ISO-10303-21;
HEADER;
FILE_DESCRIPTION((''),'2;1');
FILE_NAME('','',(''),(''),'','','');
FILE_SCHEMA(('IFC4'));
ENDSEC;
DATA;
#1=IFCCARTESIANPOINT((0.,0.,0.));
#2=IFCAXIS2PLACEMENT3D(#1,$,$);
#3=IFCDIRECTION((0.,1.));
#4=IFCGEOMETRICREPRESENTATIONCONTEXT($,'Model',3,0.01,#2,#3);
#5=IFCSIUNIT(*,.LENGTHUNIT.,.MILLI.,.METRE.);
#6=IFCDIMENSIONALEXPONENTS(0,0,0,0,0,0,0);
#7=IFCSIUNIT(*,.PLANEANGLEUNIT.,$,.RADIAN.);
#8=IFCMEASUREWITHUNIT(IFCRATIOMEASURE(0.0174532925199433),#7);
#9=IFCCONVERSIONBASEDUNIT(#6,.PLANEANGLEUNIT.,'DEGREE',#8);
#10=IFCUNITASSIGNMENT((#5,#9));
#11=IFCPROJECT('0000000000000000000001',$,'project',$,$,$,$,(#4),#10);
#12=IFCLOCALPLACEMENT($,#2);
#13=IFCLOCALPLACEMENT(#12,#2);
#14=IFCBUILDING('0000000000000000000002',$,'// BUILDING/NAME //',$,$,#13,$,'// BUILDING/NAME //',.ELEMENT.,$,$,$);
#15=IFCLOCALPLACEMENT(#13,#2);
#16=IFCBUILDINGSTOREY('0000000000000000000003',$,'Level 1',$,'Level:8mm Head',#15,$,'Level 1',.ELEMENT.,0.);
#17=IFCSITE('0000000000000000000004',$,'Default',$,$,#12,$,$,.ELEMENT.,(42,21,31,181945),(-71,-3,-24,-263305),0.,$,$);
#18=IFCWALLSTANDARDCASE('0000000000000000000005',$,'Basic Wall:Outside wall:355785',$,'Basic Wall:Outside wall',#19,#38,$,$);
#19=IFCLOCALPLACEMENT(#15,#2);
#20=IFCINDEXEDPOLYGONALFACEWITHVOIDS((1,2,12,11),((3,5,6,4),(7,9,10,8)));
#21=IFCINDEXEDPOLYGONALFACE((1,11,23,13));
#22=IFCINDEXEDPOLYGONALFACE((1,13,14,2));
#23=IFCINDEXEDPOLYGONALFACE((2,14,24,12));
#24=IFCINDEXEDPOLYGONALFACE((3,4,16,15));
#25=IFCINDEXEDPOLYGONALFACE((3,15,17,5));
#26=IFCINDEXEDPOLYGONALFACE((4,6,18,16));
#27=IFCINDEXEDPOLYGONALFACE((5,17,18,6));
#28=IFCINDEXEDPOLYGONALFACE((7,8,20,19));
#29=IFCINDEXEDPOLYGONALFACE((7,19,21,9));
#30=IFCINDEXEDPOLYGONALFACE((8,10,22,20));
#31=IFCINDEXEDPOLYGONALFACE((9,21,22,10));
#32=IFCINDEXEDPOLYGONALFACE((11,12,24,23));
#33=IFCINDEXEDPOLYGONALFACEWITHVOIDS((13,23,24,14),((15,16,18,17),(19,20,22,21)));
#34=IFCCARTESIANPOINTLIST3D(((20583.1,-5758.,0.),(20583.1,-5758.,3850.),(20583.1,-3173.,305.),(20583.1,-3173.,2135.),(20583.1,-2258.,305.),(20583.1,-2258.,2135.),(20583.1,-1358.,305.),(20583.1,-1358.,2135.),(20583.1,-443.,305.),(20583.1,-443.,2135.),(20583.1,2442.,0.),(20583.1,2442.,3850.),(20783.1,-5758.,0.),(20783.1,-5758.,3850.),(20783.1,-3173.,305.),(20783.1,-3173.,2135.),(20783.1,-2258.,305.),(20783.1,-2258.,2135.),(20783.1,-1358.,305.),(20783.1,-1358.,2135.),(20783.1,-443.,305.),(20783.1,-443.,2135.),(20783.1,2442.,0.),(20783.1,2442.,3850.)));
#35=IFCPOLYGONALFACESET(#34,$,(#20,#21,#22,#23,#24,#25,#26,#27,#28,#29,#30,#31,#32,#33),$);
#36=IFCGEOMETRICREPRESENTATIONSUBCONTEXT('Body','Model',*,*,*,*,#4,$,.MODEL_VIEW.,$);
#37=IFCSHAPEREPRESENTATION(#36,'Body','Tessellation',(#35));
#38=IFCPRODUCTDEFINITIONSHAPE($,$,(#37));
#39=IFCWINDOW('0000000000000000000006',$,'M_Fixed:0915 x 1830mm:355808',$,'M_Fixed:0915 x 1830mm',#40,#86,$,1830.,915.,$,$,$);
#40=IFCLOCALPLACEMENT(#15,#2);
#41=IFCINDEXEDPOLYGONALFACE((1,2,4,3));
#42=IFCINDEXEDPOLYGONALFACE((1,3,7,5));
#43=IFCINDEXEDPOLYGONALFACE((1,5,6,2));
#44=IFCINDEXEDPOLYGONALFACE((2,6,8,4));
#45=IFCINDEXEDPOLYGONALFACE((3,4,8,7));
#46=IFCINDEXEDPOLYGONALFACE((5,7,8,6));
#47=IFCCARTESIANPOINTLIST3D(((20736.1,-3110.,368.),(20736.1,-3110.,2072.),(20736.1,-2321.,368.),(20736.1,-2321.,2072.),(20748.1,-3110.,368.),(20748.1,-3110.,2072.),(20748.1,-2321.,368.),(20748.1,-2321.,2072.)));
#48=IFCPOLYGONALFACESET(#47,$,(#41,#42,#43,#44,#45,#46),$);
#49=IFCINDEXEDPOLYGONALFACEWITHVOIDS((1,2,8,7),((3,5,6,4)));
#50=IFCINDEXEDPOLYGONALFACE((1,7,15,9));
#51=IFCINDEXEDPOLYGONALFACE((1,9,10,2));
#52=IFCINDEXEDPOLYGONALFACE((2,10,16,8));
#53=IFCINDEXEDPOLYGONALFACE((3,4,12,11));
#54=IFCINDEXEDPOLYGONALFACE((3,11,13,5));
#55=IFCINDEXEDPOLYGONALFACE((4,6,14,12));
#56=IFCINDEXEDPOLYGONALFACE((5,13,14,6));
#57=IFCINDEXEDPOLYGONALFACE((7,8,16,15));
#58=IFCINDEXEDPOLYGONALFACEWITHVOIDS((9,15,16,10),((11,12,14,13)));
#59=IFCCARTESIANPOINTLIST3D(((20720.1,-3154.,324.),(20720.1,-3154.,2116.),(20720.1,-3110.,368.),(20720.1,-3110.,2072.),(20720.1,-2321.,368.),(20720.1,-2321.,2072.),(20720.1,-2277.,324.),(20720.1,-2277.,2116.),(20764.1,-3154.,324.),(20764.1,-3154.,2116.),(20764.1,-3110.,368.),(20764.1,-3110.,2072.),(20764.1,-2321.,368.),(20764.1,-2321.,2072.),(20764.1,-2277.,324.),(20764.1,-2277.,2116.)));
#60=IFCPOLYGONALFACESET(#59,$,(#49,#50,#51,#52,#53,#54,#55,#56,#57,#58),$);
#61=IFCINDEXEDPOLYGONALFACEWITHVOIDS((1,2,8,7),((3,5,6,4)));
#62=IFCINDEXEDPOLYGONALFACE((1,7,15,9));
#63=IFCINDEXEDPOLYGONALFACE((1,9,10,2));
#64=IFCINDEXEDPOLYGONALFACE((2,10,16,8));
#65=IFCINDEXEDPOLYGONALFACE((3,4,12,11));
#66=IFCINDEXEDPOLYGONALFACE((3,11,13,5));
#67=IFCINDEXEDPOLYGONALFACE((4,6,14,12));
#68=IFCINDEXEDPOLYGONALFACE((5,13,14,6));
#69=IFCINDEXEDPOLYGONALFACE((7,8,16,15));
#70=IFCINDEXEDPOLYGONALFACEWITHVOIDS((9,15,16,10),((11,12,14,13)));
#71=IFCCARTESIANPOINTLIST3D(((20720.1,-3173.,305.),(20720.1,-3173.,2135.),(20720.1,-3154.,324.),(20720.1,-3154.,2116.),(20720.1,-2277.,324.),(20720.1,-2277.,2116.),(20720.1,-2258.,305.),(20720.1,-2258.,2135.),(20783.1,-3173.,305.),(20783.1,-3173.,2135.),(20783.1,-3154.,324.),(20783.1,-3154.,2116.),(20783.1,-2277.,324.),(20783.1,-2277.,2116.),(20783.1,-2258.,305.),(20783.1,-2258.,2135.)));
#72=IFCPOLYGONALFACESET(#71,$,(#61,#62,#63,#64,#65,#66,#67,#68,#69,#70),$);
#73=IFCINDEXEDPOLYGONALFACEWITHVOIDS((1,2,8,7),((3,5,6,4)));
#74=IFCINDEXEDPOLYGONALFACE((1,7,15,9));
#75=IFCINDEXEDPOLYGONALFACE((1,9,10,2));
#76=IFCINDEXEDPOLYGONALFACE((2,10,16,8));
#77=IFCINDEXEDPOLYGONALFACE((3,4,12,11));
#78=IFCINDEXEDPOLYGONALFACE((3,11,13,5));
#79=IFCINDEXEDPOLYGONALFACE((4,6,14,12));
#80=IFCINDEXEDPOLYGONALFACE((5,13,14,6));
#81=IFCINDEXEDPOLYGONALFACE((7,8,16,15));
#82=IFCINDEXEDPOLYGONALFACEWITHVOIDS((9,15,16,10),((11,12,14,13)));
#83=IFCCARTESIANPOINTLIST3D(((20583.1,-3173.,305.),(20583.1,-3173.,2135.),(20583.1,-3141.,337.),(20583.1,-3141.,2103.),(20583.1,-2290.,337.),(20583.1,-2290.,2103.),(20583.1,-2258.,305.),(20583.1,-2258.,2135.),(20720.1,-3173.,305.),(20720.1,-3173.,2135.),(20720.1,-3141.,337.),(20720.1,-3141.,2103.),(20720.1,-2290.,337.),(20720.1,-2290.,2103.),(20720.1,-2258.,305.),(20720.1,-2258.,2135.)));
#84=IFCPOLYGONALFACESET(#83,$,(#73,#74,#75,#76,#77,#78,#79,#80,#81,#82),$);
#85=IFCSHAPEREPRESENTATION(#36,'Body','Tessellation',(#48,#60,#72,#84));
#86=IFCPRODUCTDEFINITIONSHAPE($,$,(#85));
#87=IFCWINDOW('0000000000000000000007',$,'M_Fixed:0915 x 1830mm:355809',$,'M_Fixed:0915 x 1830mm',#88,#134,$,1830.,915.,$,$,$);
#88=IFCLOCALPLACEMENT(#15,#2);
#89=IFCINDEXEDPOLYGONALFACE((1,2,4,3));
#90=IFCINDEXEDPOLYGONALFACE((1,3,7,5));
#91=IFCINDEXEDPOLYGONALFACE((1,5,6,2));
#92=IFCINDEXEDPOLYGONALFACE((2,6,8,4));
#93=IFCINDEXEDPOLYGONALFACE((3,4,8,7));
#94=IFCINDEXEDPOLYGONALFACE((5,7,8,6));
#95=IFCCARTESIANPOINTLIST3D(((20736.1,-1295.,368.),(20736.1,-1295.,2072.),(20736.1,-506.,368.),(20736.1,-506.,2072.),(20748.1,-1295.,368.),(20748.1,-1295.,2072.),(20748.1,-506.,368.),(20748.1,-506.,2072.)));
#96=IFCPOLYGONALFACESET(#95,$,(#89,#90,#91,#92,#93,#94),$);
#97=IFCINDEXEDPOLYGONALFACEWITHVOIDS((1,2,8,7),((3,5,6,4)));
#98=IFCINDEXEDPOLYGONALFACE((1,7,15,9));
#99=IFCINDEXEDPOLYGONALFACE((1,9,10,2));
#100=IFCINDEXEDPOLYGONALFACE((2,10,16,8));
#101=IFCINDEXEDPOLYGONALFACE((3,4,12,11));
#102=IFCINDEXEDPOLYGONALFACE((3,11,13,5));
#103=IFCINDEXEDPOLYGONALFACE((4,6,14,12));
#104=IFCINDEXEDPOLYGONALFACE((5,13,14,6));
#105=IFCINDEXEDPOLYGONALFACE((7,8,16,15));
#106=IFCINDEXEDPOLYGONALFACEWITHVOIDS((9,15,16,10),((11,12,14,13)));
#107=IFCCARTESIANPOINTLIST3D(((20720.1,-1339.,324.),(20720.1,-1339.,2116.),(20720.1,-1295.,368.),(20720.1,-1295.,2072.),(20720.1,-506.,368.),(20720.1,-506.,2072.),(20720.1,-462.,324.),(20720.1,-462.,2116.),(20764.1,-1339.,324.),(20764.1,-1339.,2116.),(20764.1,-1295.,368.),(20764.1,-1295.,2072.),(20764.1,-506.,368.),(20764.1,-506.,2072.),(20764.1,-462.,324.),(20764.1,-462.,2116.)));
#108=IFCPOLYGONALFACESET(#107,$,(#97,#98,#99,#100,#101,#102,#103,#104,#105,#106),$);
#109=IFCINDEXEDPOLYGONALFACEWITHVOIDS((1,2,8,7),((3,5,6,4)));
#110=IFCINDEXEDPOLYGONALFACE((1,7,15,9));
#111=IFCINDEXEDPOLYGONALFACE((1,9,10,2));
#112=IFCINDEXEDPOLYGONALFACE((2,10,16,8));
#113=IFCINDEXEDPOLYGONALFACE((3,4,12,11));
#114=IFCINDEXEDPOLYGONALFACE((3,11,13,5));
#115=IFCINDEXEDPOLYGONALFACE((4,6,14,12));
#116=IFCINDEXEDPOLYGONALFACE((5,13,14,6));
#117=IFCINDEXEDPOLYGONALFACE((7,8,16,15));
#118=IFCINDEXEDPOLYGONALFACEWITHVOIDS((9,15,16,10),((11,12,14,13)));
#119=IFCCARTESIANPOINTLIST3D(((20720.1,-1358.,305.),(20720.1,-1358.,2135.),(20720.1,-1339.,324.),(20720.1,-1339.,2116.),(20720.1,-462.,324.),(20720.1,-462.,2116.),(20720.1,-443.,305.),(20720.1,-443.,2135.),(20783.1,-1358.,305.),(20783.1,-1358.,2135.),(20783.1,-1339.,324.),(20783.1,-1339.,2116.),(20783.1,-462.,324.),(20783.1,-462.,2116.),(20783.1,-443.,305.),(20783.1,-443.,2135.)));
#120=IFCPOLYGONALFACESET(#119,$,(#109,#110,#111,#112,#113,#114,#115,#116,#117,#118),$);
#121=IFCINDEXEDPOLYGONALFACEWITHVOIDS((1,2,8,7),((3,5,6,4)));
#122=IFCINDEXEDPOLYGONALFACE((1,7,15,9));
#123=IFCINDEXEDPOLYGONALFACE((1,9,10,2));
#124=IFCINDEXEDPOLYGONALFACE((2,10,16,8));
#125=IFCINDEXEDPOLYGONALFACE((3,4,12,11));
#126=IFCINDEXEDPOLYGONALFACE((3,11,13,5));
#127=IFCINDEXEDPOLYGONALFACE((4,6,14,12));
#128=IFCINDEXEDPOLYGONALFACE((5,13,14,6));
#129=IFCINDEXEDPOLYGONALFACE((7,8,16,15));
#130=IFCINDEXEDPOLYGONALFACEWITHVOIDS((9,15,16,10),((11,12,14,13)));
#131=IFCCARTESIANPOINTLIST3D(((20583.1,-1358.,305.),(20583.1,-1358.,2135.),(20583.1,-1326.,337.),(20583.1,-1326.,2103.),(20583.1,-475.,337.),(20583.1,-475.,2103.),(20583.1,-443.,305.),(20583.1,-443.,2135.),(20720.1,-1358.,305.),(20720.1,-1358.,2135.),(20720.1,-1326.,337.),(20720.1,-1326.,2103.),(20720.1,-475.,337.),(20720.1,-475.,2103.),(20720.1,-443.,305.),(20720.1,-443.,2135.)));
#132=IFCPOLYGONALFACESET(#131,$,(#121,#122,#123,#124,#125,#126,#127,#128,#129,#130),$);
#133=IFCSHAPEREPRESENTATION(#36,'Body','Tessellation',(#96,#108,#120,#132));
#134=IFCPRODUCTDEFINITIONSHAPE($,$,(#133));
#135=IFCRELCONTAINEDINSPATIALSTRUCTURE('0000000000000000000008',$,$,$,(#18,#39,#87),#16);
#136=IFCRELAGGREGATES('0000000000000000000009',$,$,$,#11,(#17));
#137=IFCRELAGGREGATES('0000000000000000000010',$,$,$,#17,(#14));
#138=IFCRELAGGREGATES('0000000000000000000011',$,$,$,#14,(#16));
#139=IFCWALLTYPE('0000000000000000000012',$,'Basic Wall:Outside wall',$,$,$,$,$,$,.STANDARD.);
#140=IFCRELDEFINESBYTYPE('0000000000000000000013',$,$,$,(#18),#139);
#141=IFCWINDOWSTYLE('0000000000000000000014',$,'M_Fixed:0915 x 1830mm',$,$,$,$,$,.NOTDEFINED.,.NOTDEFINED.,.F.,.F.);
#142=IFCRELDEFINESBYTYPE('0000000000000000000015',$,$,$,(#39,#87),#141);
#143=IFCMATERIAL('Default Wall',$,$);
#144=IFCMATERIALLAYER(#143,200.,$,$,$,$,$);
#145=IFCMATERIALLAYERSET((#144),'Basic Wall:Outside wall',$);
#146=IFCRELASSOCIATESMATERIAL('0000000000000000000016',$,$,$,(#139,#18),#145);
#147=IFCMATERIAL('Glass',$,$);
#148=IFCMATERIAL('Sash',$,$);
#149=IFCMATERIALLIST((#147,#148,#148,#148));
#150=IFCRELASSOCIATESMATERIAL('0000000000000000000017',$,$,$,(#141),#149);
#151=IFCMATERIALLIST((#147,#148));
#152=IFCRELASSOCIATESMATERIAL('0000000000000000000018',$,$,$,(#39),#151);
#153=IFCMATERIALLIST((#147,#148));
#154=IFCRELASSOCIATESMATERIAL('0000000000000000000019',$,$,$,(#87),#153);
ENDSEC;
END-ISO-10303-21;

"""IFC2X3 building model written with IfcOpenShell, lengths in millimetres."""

from ifc_helpers import new_model, entity, si_unit, converted_unit, direction, frame, frame_2d, origin, place, context, subcontext, project, spatial, polyline, rectangle, outline, extrude, source, transform, mapped, material, material_list, layer, layer_set, layer_usage, type_object, type_shapes, element, fill, save


model = new_model("IFC2X3")

# Units and contexts
model_context = context("Model", 3, precision=0.01, world=origin(), true_north=direction((0.0, 1.0)))
body_context = subcontext(model_context, "Body", "Model", "MODEL_VIEW")
ifc_project = project(units=[si_unit("LENGTHUNIT", "METRE", prefix="MILLI"), converted_unit("PLANEANGLEUNIT", "DEGREE", entity("IfcRatioMeasure", 0.0174532925199433), si_unit("PLANEANGLEUNIT", "RADIAN"), dimensions=[0, 0, 0, 0, 0, 0, 0])], contexts=[model_context])

# Site, building, storey
site_placement = place(None, origin())
site = spatial("IfcSite", under=ifc_project, at=site_placement, Name="Default", CompositionType="ELEMENT", RefLatitude=(42, 21, 31, 181945), RefLongitude=(-71, -3, -24, -263305), RefElevation=0.0)
building_placement = place(site_placement, origin())
building = spatial("IfcBuilding", under=site, at=building_placement, Name="// BUILDING/NAME //", LongName="// BUILDING/NAME //", CompositionType="ELEMENT")
storey_placement = place(building_placement, origin())
storey = spatial("IfcBuildingStorey", under=building, at=storey_placement, Name="Level 1", ObjectType="Level:8mm Head", LongName="Level 1", CompositionType="ELEMENT", Elevation=0.0)

# Wall, openings, windows
ifc_material_1 = material(Name="Default Wall")
ifc_layer = layer(ifc_material_1, 200.0)
ifc_layer_set = layer_set([ifc_layer], Name="Basic Wall:Outside wall")
ifc_layer_usage = layer_usage(ifc_layer_set, "AXIS2", "NEGATIVE", 100.0)
wall_type = type_object("IfcWallType", Name="Basic Wall:Outside wall", PredefinedType="STANDARD", material=ifc_layer_set)
wall_placement = place(storey_placement, frame((20683.1, -5758.0, 0.0), z_axis=(0.0, 0.0, 1.0), x_axis=(0.0, 1.0, 0.0)))
wall = element("IfcWallStandardCase", 1, at=wall_placement, inside=storey, type_object=wall_type, material=ifc_layer_usage, Name="Basic Wall:Outside wall:355785", ObjectType="Basic Wall:Outside wall", context=body_context, shape_type="SweptSolid", body=[
    extrude(rectangle(XDim=8200.0, YDim=200.0, at=frame_2d((4100.0, 0.0), x_axis=(-1.0, 0.0))), origin(), (0.0, 0.0, 1.0), 3850.0),
])
opening_1_placement = place(wall_placement, frame((3500.0, 100.0, 305.0)))
opening_1 = element("IfcOpeningElement", 2, at=opening_1_placement, cuts=wall, ObjectType="Opening", context=body_context, shape_type="SweptSolid", body=[
    extrude(rectangle(XDim=1830.0, YDim=915.0, at=frame_2d((915.0, 457.5), x_axis=(1.0, 0.0))), frame((0.0, 0.0, 0.0), z_axis=(0.0, -1.0, 0.0), x_axis=(0.0, 0.0, 1.0)), (0.0, 0.0, 1.0), 200.0),
])
opening_2_placement = place(wall_placement, frame((5315.0, 100.0, 305.0)))
opening_2 = element("IfcOpeningElement", 3, at=opening_2_placement, cuts=wall, ObjectType="Opening", context=body_context, shape_type="SweptSolid", body=[
    extrude(rectangle(XDim=1830.0, YDim=915.0, at=frame_2d((915.0, 457.5), x_axis=(1.0, 0.0))), frame((0.0, 0.0, 0.0), z_axis=(0.0, -1.0, 0.0), x_axis=(0.0, 0.0, 1.0)), (0.0, 0.0, 1.0), 200.0),
])
ifc_material_2 = material(Name="Glass")
ifc_material_3 = material(Name="Sash")
ifc_material_list_1 = material_list([ifc_material_2, ifc_material_3])
ifc_material_list_2 = material_list([ifc_material_2, ifc_material_3, ifc_material_3, ifc_material_3])
window_style = type_object("IfcWindowStyle", Name="M_Fixed:0915 x 1830mm", ConstructionType="NOTDEFINED", OperationType="NOTDEFINED", ParameterTakesPrecedence=False, Sizeable=False, material=ifc_material_list_2)
shared_shape = source(origin(), body_context, "Body", "SweptSolid", [
    extrude(rectangle(XDim=12.0, YDim=789.0, at=frame_2d((0.0, 0.0), x_axis=(1.0, 0.0))), frame((457.5, 159.0, 63.0), z_axis=(0.0, 0.0, 1.0), x_axis=(0.0, -1.0, 0.0)), (0.0, 0.0, 1.0), 1704.0),
    extrude(outline(polyline([(-438.5, -896.0), (438.5, -896.0), (438.5, 896.0), (-438.5, 896.0), (-438.5, -896.0)]), holes=[polyline([(-394.5, -852.0), (-394.5, 852.0), (394.5, 852.0), (394.5, -852.0), (-394.5, -852.0)])]), frame((457.5, 137.0, 915.0), z_axis=(0.0, 1.0, 0.0), x_axis=(1.0, 0.0, 0.0)), (0.0, 0.0, 1.0), 44.0),
    extrude(outline(polyline([(-457.5, -915.0), (457.5, -915.0), (457.5, 915.0), (-457.5, 915.0), (-457.5, -915.0)]), holes=[polyline([(-438.5, -896.0), (-438.5, 896.0), (438.5, 896.0), (438.5, -896.0), (-438.5, -896.0)])]), frame((457.5, 137.0, 915.0), z_axis=(0.0, 1.0, 0.0), x_axis=(1.0, 0.0, 0.0)), (0.0, 0.0, 1.0), 63.0),
    extrude(outline(polyline([(-457.5, -915.0), (457.5, -915.0), (457.5, 915.0), (-457.5, 915.0), (-457.5, -915.0)]), holes=[polyline([(-425.5, -883.0), (-425.5, 883.0), (425.5, 883.0), (425.5, -883.0), (-425.5, -883.0)])]), frame((457.5, 0.0, 915.0), z_axis=(0.0, 1.0, 0.0), x_axis=(1.0, 0.0, 0.0)), (0.0, 0.0, 1.0), 137.0),
])
type_shapes(window_style, [shared_shape])
window_1_placement = place(opening_1_placement, frame((0.0, 0.0, 0.0), z_axis=(0.0, 0.0, 1.0), x_axis=(-1.0, 0.0, 0.0)))
window_1 = element("IfcWindow", 4, at=window_1_placement, inside=storey, type_object=window_style, material=ifc_material_list_1, Name="M_Fixed:0915 x 1830mm:355808", ObjectType="M_Fixed:0915 x 1830mm", OverallHeight=1830.0, OverallWidth=915.0, context=body_context, shape_type="MappedRepresentation", body=[
    mapped(shared_shape, transform((0.0, 0.0, 0.0), scale=1.0)),
])
fill(opening_1, window_1)
ifc_material_list_3 = material_list([ifc_material_2, ifc_material_3])
window_2_placement = place(opening_2_placement, frame((0.0, 0.0, 0.0), z_axis=(0.0, 0.0, 1.0), x_axis=(-1.0, 0.0, 0.0)))
window_2 = element("IfcWindow", 5, at=window_2_placement, inside=storey, type_object=window_style, material=ifc_material_list_3, Name="M_Fixed:0915 x 1830mm:355809", ObjectType="M_Fixed:0915 x 1830mm", OverallHeight=1830.0, OverallWidth=915.0, context=body_context, shape_type="MappedRepresentation", body=[
    mapped(shared_shape, transform((0.0, 0.0, 0.0), scale=1.0)),
])
fill(opening_2, window_2)

save(model, "model.ifc")
